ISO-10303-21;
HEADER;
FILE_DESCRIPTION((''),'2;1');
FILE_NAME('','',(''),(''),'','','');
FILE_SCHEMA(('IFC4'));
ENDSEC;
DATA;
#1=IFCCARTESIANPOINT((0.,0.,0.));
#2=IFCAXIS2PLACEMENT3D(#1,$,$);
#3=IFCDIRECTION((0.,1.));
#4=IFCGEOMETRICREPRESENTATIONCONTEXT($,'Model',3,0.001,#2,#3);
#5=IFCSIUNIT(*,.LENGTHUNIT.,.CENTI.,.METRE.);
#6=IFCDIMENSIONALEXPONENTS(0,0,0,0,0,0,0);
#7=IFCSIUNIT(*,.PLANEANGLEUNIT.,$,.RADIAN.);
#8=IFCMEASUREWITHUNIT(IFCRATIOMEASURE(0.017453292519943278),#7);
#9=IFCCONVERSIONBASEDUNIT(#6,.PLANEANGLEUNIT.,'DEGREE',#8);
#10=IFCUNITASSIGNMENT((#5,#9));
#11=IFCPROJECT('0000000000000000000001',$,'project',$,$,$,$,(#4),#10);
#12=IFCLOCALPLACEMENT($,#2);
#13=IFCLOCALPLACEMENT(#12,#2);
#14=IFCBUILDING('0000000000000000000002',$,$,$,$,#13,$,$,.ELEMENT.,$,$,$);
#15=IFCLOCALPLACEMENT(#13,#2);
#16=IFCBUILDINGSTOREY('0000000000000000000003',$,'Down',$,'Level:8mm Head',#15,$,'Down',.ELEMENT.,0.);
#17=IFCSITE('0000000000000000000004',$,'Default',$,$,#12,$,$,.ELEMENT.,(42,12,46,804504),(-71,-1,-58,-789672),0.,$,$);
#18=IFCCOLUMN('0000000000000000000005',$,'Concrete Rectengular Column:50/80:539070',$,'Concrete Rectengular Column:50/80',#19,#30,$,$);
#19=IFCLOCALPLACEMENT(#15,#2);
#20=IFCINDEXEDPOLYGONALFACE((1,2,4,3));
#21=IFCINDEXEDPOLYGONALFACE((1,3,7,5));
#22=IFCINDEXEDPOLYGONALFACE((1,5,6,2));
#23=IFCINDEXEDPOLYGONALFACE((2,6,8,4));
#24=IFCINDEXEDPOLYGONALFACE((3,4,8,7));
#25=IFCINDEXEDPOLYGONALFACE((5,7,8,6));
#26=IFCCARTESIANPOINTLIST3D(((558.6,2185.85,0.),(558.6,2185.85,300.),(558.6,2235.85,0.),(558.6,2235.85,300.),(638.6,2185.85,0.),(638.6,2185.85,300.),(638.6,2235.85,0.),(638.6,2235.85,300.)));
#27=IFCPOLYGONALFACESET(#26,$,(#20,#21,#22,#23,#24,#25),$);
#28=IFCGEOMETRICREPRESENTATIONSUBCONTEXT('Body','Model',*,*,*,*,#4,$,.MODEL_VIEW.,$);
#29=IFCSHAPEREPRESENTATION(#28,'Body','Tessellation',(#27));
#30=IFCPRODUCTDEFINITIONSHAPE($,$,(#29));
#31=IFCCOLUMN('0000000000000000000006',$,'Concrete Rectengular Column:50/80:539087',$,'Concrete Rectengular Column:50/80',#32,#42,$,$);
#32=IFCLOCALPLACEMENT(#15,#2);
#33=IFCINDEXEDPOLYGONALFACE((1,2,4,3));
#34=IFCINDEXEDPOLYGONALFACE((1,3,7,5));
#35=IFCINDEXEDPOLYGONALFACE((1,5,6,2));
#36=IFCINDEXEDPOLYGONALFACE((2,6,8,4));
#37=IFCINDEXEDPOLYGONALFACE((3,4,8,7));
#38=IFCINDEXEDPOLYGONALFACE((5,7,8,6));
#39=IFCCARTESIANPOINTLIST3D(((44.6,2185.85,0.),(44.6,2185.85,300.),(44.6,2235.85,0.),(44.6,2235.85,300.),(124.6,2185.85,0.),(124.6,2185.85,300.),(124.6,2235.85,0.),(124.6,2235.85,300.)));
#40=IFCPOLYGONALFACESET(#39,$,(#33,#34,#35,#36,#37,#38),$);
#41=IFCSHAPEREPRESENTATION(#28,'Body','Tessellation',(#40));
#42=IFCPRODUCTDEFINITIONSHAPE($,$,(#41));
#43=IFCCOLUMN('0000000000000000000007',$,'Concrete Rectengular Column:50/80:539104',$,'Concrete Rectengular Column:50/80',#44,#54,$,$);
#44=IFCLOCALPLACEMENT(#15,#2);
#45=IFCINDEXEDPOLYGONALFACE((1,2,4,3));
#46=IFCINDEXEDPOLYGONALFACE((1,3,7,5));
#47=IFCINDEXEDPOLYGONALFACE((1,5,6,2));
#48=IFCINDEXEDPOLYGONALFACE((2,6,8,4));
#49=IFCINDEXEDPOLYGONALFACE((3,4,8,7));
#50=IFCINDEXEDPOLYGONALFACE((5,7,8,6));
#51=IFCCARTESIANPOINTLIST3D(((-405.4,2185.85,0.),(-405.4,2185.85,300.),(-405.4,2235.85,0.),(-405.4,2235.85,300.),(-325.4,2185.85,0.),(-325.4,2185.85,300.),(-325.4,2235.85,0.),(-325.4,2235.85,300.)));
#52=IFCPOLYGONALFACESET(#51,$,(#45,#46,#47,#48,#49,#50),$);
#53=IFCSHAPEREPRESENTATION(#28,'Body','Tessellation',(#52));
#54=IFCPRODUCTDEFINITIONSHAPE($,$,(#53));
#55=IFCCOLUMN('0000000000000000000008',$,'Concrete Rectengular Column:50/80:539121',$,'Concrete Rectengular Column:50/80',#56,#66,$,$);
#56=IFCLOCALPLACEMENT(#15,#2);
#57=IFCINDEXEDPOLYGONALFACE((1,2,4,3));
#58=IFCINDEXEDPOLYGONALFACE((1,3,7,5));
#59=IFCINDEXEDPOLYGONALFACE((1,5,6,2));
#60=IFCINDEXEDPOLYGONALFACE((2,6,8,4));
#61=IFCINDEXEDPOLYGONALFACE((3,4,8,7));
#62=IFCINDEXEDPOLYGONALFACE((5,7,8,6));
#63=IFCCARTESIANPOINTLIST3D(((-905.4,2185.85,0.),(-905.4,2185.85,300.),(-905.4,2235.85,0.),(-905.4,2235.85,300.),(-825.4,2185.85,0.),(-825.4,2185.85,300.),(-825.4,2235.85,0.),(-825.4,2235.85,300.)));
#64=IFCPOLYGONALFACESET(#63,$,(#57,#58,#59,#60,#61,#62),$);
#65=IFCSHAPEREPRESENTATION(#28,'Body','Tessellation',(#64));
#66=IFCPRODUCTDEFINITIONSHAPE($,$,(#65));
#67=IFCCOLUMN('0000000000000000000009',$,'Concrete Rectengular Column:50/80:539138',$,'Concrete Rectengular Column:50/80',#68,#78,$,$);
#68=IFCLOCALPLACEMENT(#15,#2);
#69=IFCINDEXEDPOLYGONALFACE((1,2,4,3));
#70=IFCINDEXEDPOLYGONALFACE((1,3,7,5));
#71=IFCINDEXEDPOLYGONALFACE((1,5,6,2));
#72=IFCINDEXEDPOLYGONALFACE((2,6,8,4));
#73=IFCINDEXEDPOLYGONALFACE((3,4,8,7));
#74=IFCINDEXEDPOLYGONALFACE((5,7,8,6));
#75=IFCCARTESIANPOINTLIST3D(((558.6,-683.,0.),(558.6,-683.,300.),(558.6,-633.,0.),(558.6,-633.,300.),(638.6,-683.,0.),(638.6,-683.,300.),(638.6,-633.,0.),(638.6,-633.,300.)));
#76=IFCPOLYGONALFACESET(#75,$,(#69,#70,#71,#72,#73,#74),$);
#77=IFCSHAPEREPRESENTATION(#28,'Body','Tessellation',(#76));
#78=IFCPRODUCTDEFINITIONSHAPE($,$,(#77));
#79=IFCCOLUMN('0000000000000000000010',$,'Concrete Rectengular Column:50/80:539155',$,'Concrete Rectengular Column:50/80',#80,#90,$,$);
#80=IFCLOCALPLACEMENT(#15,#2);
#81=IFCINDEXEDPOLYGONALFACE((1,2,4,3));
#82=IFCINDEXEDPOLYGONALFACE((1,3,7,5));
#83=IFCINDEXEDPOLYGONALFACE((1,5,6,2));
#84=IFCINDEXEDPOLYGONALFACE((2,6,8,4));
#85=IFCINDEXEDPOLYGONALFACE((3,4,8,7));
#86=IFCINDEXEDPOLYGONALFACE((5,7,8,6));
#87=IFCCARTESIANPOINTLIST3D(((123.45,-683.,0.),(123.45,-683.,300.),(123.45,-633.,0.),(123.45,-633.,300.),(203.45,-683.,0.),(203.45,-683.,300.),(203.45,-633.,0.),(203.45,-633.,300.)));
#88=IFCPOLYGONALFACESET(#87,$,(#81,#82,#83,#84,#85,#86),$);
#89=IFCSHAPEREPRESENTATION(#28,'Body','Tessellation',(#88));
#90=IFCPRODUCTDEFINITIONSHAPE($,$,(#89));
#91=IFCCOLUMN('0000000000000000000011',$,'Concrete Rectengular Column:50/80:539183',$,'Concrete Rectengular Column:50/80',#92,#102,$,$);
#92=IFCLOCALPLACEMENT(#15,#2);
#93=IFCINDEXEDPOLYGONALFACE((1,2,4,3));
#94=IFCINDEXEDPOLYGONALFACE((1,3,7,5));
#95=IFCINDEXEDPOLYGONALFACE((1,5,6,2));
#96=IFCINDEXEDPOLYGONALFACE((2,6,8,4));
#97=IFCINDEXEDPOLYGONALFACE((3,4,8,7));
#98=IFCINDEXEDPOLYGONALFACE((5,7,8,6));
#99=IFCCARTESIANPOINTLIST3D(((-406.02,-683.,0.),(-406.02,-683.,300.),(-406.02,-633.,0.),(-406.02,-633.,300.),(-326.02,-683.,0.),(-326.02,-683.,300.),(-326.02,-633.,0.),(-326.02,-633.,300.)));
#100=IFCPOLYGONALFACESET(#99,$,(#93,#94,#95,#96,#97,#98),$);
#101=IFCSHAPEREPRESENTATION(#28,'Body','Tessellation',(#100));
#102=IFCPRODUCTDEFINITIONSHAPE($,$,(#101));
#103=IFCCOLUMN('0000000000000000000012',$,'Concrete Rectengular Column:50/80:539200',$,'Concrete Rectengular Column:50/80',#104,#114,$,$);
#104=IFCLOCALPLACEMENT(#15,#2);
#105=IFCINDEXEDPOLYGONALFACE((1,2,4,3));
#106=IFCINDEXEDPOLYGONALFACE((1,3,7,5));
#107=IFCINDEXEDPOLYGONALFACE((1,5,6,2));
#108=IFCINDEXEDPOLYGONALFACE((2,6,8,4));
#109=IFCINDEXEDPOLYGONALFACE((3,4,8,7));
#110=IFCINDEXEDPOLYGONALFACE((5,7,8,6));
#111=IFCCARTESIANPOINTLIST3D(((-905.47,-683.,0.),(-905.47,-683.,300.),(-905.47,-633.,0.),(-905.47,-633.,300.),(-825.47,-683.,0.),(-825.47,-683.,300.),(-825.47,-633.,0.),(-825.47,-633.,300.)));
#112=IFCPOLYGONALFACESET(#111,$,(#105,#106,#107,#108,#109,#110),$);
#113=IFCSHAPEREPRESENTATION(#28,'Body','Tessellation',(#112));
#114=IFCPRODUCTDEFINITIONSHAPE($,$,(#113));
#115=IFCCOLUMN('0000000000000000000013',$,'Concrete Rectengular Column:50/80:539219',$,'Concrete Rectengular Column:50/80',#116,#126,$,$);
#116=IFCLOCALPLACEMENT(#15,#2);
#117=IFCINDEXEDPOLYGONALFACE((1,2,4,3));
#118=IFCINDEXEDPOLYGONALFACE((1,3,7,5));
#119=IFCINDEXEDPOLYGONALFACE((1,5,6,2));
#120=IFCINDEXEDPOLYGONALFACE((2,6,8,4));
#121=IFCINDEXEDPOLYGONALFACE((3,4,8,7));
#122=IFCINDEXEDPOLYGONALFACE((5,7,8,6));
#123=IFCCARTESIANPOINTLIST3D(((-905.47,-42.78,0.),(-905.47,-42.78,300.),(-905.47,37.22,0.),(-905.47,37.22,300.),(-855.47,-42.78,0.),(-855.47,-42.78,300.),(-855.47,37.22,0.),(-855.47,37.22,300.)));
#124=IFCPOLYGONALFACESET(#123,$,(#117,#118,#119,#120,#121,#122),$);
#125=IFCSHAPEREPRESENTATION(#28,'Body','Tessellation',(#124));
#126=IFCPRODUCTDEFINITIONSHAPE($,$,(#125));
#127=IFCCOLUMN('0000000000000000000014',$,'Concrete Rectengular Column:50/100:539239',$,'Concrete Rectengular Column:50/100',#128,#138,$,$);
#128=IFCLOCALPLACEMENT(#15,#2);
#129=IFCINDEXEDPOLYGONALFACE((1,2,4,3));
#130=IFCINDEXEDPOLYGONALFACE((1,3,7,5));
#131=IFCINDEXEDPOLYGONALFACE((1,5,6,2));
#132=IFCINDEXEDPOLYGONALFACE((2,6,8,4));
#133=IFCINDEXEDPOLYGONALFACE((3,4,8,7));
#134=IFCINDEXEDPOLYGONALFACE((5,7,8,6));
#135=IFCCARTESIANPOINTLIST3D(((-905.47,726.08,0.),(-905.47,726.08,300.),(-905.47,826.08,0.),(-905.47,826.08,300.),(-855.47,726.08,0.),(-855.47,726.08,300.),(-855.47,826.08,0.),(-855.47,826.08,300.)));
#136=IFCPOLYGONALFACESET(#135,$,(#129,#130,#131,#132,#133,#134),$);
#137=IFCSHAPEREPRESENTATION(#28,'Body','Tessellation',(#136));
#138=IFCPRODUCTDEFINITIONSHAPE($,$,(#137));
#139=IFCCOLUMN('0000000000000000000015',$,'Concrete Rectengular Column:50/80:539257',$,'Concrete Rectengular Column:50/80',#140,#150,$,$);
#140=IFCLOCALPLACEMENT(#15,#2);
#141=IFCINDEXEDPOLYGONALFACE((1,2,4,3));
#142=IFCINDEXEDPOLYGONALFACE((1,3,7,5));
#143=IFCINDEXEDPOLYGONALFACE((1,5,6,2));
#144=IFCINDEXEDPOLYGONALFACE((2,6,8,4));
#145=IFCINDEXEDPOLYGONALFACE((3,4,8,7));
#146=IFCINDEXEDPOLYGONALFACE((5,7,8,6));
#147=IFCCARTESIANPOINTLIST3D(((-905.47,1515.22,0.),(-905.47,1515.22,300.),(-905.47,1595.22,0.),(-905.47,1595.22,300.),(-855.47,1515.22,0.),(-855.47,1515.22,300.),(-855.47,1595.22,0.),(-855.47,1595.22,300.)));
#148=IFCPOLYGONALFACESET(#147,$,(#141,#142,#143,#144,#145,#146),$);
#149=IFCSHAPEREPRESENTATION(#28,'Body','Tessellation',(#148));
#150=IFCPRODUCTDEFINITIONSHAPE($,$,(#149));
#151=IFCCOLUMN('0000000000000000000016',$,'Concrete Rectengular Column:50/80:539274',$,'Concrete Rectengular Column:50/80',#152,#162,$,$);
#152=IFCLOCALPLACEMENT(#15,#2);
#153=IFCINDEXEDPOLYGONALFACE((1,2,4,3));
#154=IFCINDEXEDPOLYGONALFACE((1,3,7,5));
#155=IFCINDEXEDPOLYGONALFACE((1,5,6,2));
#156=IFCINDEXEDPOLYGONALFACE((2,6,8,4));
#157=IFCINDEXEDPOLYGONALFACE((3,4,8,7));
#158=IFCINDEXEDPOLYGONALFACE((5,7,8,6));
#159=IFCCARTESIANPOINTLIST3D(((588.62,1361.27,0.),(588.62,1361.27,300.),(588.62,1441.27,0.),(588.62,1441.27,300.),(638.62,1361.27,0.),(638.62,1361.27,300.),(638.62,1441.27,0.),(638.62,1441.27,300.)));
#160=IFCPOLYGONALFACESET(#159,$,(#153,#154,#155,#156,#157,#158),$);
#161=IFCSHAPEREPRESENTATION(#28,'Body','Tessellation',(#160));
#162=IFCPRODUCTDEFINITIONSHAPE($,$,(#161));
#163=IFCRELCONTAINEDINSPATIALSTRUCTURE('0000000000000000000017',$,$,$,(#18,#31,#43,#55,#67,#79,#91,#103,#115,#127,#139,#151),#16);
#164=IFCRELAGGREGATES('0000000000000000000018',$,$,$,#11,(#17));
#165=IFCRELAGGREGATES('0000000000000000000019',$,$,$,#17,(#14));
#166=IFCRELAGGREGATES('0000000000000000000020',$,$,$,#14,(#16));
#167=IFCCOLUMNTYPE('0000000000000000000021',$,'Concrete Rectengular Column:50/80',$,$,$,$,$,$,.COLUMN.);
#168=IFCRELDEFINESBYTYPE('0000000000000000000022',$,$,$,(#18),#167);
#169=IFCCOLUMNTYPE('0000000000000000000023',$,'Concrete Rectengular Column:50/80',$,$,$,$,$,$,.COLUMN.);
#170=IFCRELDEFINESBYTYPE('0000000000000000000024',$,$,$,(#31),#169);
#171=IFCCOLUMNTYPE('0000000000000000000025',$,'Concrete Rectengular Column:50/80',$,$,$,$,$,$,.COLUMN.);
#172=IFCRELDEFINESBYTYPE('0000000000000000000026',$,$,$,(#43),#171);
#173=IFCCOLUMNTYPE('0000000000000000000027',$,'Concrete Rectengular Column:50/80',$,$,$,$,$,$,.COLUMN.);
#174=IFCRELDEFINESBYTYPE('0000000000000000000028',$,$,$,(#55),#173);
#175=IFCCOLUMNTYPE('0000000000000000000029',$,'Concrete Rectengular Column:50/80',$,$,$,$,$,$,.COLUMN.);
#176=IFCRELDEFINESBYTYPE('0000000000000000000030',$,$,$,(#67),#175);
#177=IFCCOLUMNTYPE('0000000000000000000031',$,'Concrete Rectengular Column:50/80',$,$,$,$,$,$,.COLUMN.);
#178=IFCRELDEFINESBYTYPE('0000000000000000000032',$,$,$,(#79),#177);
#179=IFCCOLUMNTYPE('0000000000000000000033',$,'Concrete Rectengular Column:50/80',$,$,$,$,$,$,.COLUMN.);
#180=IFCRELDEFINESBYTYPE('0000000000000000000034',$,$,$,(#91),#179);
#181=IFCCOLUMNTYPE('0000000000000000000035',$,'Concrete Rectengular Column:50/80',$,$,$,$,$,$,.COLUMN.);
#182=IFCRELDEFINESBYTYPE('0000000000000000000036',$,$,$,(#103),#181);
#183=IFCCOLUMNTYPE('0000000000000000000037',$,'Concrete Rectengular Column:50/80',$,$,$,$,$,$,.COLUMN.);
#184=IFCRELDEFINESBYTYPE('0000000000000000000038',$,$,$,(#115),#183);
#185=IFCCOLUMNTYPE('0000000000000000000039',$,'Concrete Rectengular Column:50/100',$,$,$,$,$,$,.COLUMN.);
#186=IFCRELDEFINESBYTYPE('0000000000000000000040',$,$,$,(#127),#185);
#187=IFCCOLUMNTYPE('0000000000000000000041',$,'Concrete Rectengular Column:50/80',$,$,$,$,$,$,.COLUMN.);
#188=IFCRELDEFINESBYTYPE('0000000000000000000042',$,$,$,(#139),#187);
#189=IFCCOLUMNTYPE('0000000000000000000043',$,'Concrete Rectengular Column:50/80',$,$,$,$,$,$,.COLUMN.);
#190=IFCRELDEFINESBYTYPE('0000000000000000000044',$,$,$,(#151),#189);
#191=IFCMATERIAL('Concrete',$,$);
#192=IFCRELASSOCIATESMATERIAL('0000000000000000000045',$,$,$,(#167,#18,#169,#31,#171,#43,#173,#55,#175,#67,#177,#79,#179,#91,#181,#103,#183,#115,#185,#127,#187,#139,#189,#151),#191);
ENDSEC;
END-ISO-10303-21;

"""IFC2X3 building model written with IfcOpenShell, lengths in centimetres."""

from ifc_helpers import new_model, entity, si_unit, converted_unit, direction, frame, frame_2d, origin, origin_2d_with_axis, place, context, subcontext, project, spatial, rectangle, extrude, source, transform, mapped, material, type_object, type_shapes, element, save


model = new_model("IFC2X3")

# Units and contexts
model_context = context("Model", 3, precision=0.001, world=origin(), true_north=direction((0.0, 1.0)))
body_context = subcontext(model_context, "Body", "Model", "MODEL_VIEW")
ifc_project = project(units=[si_unit("LENGTHUNIT", "METRE", prefix="CENTI"), converted_unit("PLANEANGLEUNIT", "DEGREE", entity("IfcRatioMeasure", 0.017453292519943278), si_unit("PLANEANGLEUNIT", "RADIAN"), dimensions=[0, 0, 0, 0, 0, 0, 0])], contexts=[model_context])

# Site, building, storey
site_placement = place(None, origin())
site = spatial("IfcSite", under=ifc_project, at=site_placement, Name="Default", CompositionType="ELEMENT", RefLatitude=(42, 12, 46, 804504), RefLongitude=(-71, -1, -58, -789672), RefElevation=0.0)
building_placement = place(site_placement, origin())
building = spatial("IfcBuilding", under=site, at=building_placement, CompositionType="ELEMENT")
storey_placement = place(building_placement, origin())
storey = spatial("IfcBuildingStorey", under=building, at=storey_placement, Name="Down", ObjectType="Level:8mm Head", LongName="Down", CompositionType="ELEMENT", Elevation=0.0)

# Columns
ifc_material = material(Name="Concrete")
column_type_1 = type_object("IfcColumnType", Name="Concrete Rectengular Column:50/80", PredefinedType="COLUMN", material=ifc_material)
shared_shape_1 = source(origin(), body_context, "Body", "SweptSolid", [
    extrude(rectangle(XDim=50.0, YDim=80.0, at=origin_2d_with_axis()), frame((598.6, 2210.85, 0.0), z_axis=(0.0, 0.0, 1.0), x_axis=(0.0, -1.0, 0.0)), (0.0, 0.0, 1.0), 300.0),
])
type_shapes(column_type_1, [shared_shape_1])
column_1_placement = place(storey_placement, origin())
element("IfcColumn", 1, at=column_1_placement, inside=storey, type_object=column_type_1, material=ifc_material, Name="Concrete Rectengular Column:50/80:539070", ObjectType="Concrete Rectengular Column:50/80", context=body_context, shape_type="MappedRepresentation", body=[
    mapped(shared_shape_1, transform((0.0, 0.0, 0.0), scale=1.0)),
])
column_type_2 = type_object("IfcColumnType", Name="Concrete Rectengular Column:50/80", PredefinedType="COLUMN", material=ifc_material)
shared_shape_2 = source(origin(), body_context, "Body", "SweptSolid", [
    extrude(rectangle(XDim=50.0, YDim=80.0, at=frame_2d((0.0, 0.0), x_axis=(1.0, 0.0))), frame((84.6, 2210.85, 0.0), z_axis=(0.0, 0.0, 1.0), x_axis=(0.0, -1.0, 0.0)), (0.0, 0.0, 1.0), 300.0),
])
type_shapes(column_type_2, [shared_shape_2])
column_2_placement = place(storey_placement, origin())
element("IfcColumn", 2, at=column_2_placement, inside=storey, type_object=column_type_2, material=ifc_material, Name="Concrete Rectengular Column:50/80:539087", ObjectType="Concrete Rectengular Column:50/80", context=body_context, shape_type="MappedRepresentation", body=[
    mapped(shared_shape_2, transform((0.0, 0.0, 0.0), scale=1.0)),
])
column_type_3 = type_object("IfcColumnType", Name="Concrete Rectengular Column:50/80", PredefinedType="COLUMN", material=ifc_material)
shared_shape_3 = source(origin(), body_context, "Body", "SweptSolid", [
    extrude(rectangle(XDim=50.0, YDim=80.0, at=origin_2d_with_axis()), frame((-365.4, 2210.85, 0.0), z_axis=(0.0, 0.0, 1.0), x_axis=(0.0, -1.0, 0.0)), (0.0, 0.0, 1.0), 300.0),
])
type_shapes(column_type_3, [shared_shape_3])
column_3_placement = place(storey_placement, origin())
element("IfcColumn", 3, at=column_3_placement, inside=storey, type_object=column_type_3, material=ifc_material, Name="Concrete Rectengular Column:50/80:539104", ObjectType="Concrete Rectengular Column:50/80", context=body_context, shape_type="MappedRepresentation", body=[
    mapped(shared_shape_3, transform((0.0, 0.0, 0.0), scale=1.0)),
])
column_type_4 = type_object("IfcColumnType", Name="Concrete Rectengular Column:50/80", PredefinedType="COLUMN", material=ifc_material)
shared_shape_4 = source(origin(), body_context, "Body", "SweptSolid", [
    extrude(rectangle(XDim=50.0, YDim=80.0, at=origin_2d_with_axis()), frame((-865.4, 2210.85, 0.0), z_axis=(0.0, 0.0, 1.0), x_axis=(0.0, -1.0, 0.0)), (0.0, 0.0, 1.0), 300.0),
])
type_shapes(column_type_4, [shared_shape_4])
column_4_placement = place(storey_placement, origin())
element("IfcColumn", 4, at=column_4_placement, inside=storey, type_object=column_type_4, material=ifc_material, Name="Concrete Rectengular Column:50/80:539121", ObjectType="Concrete Rectengular Column:50/80", context=body_context, shape_type="MappedRepresentation", body=[
    mapped(shared_shape_4, transform((0.0, 0.0, 0.0), scale=1.0)),
])
column_type_5 = type_object("IfcColumnType", Name="Concrete Rectengular Column:50/80", PredefinedType="COLUMN", material=ifc_material)
shared_shape_5 = source(origin(), body_context, "Body", "SweptSolid", [
    extrude(rectangle(XDim=50.0, YDim=80.0, at=frame_2d((0.0, 0.0), x_axis=(1.0, 0.0))), frame((598.6, -658.0, 0.0), z_axis=(0.0, 0.0, 1.0), x_axis=(0.0, -1.0, 0.0)), (0.0, 0.0, 1.0), 300.0),
])
type_shapes(column_type_5, [shared_shape_5])
column_5_placement = place(storey_placement, origin())
element("IfcColumn", 5, at=column_5_placement, inside=storey, type_object=column_type_5, material=ifc_material, Name="Concrete Rectengular Column:50/80:539138", ObjectType="Concrete Rectengular Column:50/80", context=body_context, shape_type="MappedRepresentation", body=[
    mapped(shared_shape_5, transform((0.0, 0.0, 0.0), scale=1.0)),
])
column_type_6 = type_object("IfcColumnType", Name="Concrete Rectengular Column:50/80", PredefinedType="COLUMN", material=ifc_material)
shared_shape_6 = source(origin(), body_context, "Body", "SweptSolid", [
    extrude(rectangle(XDim=50.0, YDim=80.0, at=frame_2d((0.0, 0.0), x_axis=(1.0, 0.0))), frame((163.45, -658.0, 0.0), z_axis=(0.0, 0.0, 1.0), x_axis=(0.0, -1.0, 0.0)), (0.0, 0.0, 1.0), 300.0),
])
type_shapes(column_type_6, [shared_shape_6])
column_6_placement = place(storey_placement, origin())
element("IfcColumn", 6, at=column_6_placement, inside=storey, type_object=column_type_6, material=ifc_material, Name="Concrete Rectengular Column:50/80:539155", ObjectType="Concrete Rectengular Column:50/80", context=body_context, shape_type="MappedRepresentation", body=[
    mapped(shared_shape_6, transform((0.0, 0.0, 0.0), scale=1.0)),
])
column_type_7 = type_object("IfcColumnType", Name="Concrete Rectengular Column:50/80", PredefinedType="COLUMN", material=ifc_material)
shared_shape_7 = source(origin(), body_context, "Body", "SweptSolid", [
    extrude(rectangle(XDim=50.0, YDim=80.0, at=frame_2d((0.0, 0.0), x_axis=(1.0, 0.0))), frame((-366.02, -658.0, 0.0), z_axis=(0.0, 0.0, 1.0), x_axis=(0.0, -1.0, 0.0)), (0.0, 0.0, 1.0), 300.0),
])
type_shapes(column_type_7, [shared_shape_7])
column_7_placement = place(storey_placement, origin())
element("IfcColumn", 7, at=column_7_placement, inside=storey, type_object=column_type_7, material=ifc_material, Name="Concrete Rectengular Column:50/80:539183", ObjectType="Concrete Rectengular Column:50/80", context=body_context, shape_type="MappedRepresentation", body=[
    mapped(shared_shape_7, transform((0.0, 0.0, 0.0), scale=1.0)),
])
column_type_8 = type_object("IfcColumnType", Name="Concrete Rectengular Column:50/80", PredefinedType="COLUMN", material=ifc_material)
shared_shape_8 = source(origin(), body_context, "Body", "SweptSolid", [
    extrude(rectangle(XDim=50.0, YDim=80.0, at=frame_2d((0.0, 0.0), x_axis=(1.0, 0.0))), frame((-865.47, -658.0, 0.0), z_axis=(0.0, 0.0, 1.0), x_axis=(0.0, -1.0, 0.0)), (0.0, 0.0, 1.0), 300.0),
])
type_shapes(column_type_8, [shared_shape_8])
column_8_placement = place(storey_placement, origin())
element("IfcColumn", 8, at=column_8_placement, inside=storey, type_object=column_type_8, material=ifc_material, Name="Concrete Rectengular Column:50/80:539200", ObjectType="Concrete Rectengular Column:50/80", context=body_context, shape_type="MappedRepresentation", body=[
    mapped(shared_shape_8, transform((0.0, 0.0, 0.0), scale=1.0)),
])
column_type_9 = type_object("IfcColumnType", Name="Concrete Rectengular Column:50/80", PredefinedType="COLUMN", material=ifc_material)
shared_shape_9 = source(origin(), body_context, "Body", "SweptSolid", [
    extrude(rectangle(XDim=80.0, YDim=50.0, at=frame_2d((0.0, 0.0), x_axis=(1.0, 0.0))), frame((-880.47, -2.78, 0.0), z_axis=(0.0, 0.0, 1.0), x_axis=(0.0, -1.0, 0.0)), (0.0, 0.0, 1.0), 300.0),
])
type_shapes(column_type_9, [shared_shape_9])
column_9_placement = place(storey_placement, origin())
element("IfcColumn", 9, at=column_9_placement, inside=storey, type_object=column_type_9, material=ifc_material, Name="Concrete Rectengular Column:50/80:539219", ObjectType="Concrete Rectengular Column:50/80", context=body_context, shape_type="MappedRepresentation", body=[
    mapped(shared_shape_9, transform((0.0, 0.0, 0.0), scale=1.0)),
])
column_type_10 = type_object("IfcColumnType", Name="Concrete Rectengular Column:50/100", PredefinedType="COLUMN", material=ifc_material)
shared_shape_10 = source(origin(), body_context, "Body", "SweptSolid", [
    extrude(rectangle(XDim=100.0, YDim=50.0, at=frame_2d((0.0, 0.0), x_axis=(1.0, 0.0))), frame((-880.47, 776.08, 0.0), z_axis=(0.0, 0.0, 1.0), x_axis=(0.0, -1.0, 0.0)), (0.0, 0.0, 1.0), 300.0),
])
type_shapes(column_type_10, [shared_shape_10])
column_10_placement = place(storey_placement, origin())
element("IfcColumn", 10, at=column_10_placement, inside=storey, type_object=column_type_10, material=ifc_material, Name="Concrete Rectengular Column:50/100:539239", ObjectType="Concrete Rectengular Column:50/100", context=body_context, shape_type="MappedRepresentation", body=[
    mapped(shared_shape_10, transform((0.0, 0.0, 0.0), scale=1.0)),
])
column_type_11 = type_object("IfcColumnType", Name="Concrete Rectengular Column:50/80", PredefinedType="COLUMN", material=ifc_material)
shared_shape_11 = source(origin(), body_context, "Body", "SweptSolid", [
    extrude(rectangle(XDim=80.0, YDim=50.0, at=frame_2d((0.0, 0.0), x_axis=(1.0, 0.0))), frame((-880.47, 1555.22, 0.0), z_axis=(0.0, 0.0, 1.0), x_axis=(0.0, -1.0, 0.0)), (0.0, 0.0, 1.0), 300.0),
])
type_shapes(column_type_11, [shared_shape_11])
column_11_placement = place(storey_placement, origin())
element("IfcColumn", 11, at=column_11_placement, inside=storey, type_object=column_type_11, material=ifc_material, Name="Concrete Rectengular Column:50/80:539257", ObjectType="Concrete Rectengular Column:50/80", context=body_context, shape_type="MappedRepresentation", body=[
    mapped(shared_shape_11, transform((0.0, 0.0, 0.0), scale=1.0)),
])
column_type_12 = type_object("IfcColumnType", Name="Concrete Rectengular Column:50/80", PredefinedType="COLUMN", material=ifc_material)
shared_shape_12 = source(origin(), body_context, "Body", "SweptSolid", [
    extrude(rectangle(XDim=80.0, YDim=50.0, at=frame_2d((0.0, 0.0), x_axis=(1.0, 0.0))), frame((613.62, 1401.27, 0.0), z_axis=(0.0, 0.0, 1.0), x_axis=(0.0, -1.0, 0.0)), (0.0, 0.0, 1.0), 300.0),
])
type_shapes(column_type_12, [shared_shape_12])
column_12_placement = place(storey_placement, origin())
element("IfcColumn", 12, at=column_12_placement, inside=storey, type_object=column_type_12, material=ifc_material, Name="Concrete Rectengular Column:50/80:539274", ObjectType="Concrete Rectengular Column:50/80", context=body_context, shape_type="MappedRepresentation", body=[
    mapped(shared_shape_12, transform((0.0, 0.0, 0.0), scale=1.0)),
])

save(model, "model.ifc")
